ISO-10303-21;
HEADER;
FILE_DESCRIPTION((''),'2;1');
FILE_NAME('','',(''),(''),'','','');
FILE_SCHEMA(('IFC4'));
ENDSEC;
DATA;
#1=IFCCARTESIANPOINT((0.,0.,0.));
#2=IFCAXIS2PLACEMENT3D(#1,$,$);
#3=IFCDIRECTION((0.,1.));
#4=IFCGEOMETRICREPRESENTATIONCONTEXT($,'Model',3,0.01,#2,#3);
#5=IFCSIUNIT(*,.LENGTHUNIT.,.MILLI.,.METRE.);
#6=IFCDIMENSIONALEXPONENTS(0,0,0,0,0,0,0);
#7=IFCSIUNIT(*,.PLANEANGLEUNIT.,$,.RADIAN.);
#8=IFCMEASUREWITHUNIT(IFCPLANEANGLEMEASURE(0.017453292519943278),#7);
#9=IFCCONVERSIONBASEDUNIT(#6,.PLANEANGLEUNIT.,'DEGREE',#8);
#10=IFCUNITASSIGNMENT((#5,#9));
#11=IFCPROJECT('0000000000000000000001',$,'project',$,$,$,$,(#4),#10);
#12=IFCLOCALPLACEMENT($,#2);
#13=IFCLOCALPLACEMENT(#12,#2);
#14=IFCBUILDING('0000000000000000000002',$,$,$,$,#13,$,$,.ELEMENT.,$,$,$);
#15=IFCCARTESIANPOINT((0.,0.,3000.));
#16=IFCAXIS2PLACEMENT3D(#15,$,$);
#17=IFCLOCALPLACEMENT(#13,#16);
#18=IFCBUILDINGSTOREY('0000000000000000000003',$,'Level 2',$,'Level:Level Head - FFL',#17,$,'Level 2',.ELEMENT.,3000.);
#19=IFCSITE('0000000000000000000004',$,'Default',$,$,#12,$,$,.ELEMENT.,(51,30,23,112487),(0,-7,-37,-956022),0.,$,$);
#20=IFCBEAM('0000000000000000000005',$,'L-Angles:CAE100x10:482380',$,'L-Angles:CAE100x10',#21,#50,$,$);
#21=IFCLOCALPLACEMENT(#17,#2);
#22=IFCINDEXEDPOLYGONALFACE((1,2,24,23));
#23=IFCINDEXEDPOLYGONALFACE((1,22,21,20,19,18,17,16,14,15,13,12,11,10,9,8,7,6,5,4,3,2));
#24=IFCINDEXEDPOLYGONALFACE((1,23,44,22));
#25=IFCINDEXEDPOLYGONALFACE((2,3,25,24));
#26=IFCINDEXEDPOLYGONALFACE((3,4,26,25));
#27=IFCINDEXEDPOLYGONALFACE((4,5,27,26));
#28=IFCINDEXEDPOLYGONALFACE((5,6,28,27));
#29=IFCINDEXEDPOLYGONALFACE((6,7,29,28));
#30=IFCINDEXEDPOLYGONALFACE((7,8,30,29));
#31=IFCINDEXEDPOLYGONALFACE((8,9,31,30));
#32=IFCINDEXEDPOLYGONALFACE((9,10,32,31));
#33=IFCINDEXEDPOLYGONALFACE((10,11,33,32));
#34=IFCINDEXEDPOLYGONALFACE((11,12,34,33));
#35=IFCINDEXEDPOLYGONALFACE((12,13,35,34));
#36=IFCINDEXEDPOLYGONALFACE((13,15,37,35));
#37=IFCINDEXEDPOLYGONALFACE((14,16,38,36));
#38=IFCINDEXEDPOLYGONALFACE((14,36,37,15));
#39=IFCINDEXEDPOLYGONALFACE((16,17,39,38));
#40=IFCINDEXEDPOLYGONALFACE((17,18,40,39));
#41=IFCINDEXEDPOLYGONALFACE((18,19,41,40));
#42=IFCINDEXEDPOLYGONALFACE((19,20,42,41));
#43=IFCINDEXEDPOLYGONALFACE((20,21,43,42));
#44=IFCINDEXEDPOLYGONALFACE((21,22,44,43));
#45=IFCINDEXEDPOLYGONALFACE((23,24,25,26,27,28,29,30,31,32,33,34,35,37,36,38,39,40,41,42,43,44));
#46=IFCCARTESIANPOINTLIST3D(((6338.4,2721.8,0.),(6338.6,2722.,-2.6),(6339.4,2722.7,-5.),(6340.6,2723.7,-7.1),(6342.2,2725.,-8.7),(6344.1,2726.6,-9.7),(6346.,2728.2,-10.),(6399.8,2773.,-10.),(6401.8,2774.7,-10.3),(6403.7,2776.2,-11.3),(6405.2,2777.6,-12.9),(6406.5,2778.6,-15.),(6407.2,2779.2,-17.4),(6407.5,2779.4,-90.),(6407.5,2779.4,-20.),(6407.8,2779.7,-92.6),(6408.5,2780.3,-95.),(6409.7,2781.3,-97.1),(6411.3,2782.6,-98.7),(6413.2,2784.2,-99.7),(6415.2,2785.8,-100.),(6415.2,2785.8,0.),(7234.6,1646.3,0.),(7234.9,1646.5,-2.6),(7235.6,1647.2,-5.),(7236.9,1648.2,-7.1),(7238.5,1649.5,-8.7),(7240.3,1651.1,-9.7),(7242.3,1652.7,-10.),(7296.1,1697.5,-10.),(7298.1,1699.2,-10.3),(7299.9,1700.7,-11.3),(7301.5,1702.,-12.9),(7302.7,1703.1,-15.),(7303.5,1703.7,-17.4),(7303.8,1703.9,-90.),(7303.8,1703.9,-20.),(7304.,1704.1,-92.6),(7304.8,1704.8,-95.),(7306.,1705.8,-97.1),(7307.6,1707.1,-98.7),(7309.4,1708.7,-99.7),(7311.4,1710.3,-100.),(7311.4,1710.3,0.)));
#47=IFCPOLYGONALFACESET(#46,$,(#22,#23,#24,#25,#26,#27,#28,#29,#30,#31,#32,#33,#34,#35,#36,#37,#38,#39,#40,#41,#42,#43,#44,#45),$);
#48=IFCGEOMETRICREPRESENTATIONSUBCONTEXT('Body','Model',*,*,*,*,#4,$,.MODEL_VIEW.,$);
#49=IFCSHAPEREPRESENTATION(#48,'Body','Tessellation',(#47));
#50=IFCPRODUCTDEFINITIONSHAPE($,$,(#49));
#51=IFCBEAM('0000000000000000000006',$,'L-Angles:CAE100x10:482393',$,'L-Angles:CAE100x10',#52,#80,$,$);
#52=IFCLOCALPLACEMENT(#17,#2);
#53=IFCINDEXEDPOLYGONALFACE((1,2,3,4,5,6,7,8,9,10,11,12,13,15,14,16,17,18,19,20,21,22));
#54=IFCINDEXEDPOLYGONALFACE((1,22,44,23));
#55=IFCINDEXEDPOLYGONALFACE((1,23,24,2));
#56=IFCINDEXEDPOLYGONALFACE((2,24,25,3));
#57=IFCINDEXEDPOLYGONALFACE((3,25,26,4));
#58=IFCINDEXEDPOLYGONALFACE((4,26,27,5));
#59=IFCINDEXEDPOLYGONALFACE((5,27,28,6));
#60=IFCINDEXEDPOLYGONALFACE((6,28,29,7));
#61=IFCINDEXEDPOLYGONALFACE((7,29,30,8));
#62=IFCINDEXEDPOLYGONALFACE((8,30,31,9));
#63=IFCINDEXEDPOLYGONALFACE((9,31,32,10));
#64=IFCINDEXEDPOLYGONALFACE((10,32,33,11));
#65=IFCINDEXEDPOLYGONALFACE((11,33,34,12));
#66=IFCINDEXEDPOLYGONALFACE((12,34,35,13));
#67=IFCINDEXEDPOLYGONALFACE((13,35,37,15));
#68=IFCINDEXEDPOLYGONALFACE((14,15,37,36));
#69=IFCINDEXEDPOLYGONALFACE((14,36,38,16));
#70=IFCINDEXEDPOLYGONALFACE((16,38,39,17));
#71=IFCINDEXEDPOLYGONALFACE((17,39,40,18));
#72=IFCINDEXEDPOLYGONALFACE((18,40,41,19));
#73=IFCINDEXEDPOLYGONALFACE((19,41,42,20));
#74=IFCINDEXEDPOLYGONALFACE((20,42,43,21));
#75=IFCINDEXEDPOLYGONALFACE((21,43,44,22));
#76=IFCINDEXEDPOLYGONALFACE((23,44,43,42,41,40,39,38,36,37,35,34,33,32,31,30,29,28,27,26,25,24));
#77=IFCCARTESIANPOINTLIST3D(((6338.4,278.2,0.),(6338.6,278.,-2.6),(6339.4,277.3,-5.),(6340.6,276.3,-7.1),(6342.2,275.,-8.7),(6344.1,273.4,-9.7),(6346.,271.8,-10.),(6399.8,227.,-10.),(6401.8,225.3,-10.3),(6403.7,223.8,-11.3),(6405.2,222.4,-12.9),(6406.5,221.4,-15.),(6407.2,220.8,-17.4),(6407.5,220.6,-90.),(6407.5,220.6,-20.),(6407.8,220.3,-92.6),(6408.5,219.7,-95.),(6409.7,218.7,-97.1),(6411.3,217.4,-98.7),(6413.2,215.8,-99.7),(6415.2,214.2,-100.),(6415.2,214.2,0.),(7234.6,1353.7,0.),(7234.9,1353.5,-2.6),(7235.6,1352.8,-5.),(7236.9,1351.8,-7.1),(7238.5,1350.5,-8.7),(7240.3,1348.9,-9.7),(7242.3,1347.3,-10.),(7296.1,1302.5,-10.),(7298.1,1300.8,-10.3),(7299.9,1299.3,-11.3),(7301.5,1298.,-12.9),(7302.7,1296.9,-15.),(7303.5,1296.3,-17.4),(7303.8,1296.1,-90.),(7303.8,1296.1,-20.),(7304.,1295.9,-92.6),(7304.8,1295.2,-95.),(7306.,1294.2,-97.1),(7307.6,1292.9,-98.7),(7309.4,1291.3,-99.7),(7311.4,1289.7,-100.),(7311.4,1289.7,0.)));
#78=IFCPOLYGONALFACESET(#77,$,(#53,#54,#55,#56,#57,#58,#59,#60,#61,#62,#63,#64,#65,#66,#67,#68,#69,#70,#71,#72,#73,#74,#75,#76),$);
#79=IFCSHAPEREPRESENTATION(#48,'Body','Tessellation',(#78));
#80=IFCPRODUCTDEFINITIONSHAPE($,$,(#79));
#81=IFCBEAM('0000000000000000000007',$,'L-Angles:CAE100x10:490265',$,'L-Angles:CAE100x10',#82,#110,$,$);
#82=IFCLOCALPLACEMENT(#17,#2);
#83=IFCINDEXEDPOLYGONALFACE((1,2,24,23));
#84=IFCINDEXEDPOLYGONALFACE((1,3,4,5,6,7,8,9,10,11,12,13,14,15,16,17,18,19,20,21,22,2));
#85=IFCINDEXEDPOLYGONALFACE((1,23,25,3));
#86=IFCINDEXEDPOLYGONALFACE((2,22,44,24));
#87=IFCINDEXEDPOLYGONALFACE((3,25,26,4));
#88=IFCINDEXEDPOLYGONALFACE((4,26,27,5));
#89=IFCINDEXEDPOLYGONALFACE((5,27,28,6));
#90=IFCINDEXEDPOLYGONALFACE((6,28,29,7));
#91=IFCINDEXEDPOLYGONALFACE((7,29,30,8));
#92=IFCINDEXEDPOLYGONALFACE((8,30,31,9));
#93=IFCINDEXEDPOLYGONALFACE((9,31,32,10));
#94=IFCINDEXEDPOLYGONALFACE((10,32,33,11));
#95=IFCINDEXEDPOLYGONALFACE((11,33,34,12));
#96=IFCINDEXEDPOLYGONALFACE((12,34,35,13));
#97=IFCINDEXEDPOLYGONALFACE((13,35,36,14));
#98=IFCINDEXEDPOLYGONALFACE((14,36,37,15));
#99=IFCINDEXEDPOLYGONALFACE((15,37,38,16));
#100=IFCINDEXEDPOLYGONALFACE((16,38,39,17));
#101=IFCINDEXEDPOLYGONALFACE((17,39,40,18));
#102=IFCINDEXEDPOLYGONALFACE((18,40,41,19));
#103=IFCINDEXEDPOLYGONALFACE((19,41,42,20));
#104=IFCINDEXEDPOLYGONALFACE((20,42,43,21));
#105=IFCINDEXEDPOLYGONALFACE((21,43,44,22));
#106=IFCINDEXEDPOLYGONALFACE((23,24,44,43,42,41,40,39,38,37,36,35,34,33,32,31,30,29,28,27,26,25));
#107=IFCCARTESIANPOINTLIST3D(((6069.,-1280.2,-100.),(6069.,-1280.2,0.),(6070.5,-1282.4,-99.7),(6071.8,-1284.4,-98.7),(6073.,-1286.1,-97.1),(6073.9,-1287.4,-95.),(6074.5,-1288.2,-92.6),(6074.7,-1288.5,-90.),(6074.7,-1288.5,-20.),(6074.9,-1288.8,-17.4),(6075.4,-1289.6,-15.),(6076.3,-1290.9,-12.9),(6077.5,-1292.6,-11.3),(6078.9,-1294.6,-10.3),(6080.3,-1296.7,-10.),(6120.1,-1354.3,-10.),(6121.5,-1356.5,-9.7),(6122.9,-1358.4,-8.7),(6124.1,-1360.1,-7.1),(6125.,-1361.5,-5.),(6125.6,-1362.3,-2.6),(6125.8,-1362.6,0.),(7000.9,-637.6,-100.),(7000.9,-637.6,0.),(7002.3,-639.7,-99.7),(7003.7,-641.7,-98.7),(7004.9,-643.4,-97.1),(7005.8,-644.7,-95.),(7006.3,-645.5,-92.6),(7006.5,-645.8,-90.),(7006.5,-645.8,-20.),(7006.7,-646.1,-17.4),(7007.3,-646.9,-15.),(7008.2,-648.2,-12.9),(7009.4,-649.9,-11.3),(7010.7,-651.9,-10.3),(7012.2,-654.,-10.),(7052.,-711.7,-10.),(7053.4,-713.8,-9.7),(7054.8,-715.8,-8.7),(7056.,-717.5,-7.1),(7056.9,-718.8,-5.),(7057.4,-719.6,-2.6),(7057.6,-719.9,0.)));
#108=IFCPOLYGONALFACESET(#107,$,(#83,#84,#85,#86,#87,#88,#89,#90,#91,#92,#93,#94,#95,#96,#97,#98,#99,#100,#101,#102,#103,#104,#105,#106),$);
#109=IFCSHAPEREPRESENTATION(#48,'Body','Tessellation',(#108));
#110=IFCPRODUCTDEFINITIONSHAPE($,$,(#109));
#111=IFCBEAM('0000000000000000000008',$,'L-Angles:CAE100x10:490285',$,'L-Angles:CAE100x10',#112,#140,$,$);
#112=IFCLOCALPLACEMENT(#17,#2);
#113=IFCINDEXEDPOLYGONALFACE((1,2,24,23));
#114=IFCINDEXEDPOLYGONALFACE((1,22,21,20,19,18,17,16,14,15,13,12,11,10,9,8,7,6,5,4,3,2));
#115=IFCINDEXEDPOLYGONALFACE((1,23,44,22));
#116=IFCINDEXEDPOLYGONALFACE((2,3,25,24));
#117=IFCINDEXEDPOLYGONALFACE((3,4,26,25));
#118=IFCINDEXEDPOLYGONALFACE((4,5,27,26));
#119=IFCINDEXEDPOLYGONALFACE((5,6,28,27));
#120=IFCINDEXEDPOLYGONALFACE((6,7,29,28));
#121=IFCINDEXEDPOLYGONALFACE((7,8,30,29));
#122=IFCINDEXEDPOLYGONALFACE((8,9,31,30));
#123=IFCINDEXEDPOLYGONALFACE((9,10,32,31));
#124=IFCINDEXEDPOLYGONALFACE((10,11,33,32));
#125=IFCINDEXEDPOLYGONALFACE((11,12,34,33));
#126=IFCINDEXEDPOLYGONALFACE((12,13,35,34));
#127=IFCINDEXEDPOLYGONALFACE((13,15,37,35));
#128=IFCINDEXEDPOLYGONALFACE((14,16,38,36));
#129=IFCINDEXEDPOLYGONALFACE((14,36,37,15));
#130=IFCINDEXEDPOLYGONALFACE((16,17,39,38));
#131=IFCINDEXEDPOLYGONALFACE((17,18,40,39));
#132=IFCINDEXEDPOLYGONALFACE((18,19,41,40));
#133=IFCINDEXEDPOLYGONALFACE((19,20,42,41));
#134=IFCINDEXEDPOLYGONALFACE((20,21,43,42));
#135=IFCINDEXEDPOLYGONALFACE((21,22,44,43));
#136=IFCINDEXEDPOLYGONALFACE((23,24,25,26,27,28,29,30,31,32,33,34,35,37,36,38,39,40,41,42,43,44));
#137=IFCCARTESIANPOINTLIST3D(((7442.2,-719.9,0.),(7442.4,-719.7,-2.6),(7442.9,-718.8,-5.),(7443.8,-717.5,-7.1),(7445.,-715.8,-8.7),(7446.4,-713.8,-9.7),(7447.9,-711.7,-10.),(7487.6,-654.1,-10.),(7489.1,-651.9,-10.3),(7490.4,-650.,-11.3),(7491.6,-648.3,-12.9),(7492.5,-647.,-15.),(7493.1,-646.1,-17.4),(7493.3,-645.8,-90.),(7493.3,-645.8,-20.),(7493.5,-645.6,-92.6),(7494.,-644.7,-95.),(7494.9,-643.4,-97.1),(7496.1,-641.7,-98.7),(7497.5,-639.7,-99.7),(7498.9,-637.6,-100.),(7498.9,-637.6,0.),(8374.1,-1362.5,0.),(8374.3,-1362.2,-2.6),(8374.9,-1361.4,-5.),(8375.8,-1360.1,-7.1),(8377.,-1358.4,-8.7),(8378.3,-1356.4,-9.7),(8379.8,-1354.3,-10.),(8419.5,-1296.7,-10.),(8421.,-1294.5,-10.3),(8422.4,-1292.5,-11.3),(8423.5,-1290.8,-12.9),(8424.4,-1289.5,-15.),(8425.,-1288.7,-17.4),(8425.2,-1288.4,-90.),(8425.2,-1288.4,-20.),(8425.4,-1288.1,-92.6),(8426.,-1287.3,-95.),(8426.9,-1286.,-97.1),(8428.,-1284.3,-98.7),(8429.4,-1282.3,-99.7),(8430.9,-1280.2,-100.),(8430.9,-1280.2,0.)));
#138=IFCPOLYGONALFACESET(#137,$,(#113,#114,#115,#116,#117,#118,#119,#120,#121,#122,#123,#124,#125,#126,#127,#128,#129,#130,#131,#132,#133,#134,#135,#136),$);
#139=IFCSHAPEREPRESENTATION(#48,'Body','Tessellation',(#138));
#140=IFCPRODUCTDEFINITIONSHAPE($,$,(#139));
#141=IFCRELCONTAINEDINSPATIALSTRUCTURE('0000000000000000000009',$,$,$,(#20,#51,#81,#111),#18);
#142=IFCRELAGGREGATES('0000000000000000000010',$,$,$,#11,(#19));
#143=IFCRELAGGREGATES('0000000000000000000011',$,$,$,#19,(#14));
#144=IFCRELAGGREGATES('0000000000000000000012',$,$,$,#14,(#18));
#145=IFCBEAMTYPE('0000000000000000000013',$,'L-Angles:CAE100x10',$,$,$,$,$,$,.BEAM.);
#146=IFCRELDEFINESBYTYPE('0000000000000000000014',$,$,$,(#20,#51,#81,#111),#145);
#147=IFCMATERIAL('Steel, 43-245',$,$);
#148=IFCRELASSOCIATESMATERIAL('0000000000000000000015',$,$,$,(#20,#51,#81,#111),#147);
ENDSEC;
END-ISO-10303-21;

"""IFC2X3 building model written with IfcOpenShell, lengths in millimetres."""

from ifc_helpers import new_model, entity, si_unit, converted_unit, direction, frame, frame_2d, origin, place, context, subcontext, project, spatial, polyline, circle_curve, parameter, trimmed, segment, composite_curve, outline, extrude, material, type_object, element, save


model = new_model("IFC2X3")

# Units and contexts
model_context = context("Model", 3, precision=0.01, world=origin(), true_north=direction((0.0, 1.0)))
body_context = subcontext(model_context, "Body", "Model", "MODEL_VIEW")
ifc_project = project(units=[si_unit("LENGTHUNIT", "METRE", prefix="MILLI"), converted_unit("PLANEANGLEUNIT", "DEGREE", entity("IfcPlaneAngleMeasure", 0.017453292519943278), si_unit("PLANEANGLEUNIT", "RADIAN"), dimensions=[0, 0, 0, 0, 0, 0, 0])], contexts=[model_context])

# Site, building, storey
site_placement = place(None, origin())
site = spatial("IfcSite", under=ifc_project, at=site_placement, Name="Default", CompositionType="ELEMENT", RefLatitude=(51, 30, 23, 112487), RefLongitude=(0, -7, -37, -956022), RefElevation=0.0)
building_placement = place(site_placement, origin())
building = spatial("IfcBuilding", under=site, at=building_placement, CompositionType="ELEMENT")
storey_placement = place(building_placement, frame((0.0, 0.0, 3000.0)))
storey = spatial("IfcBuildingStorey", under=building, at=storey_placement, Name="Level 2", ObjectType="Level:Level Head - FFL", LongName="Level 2", CompositionType="ELEMENT", Elevation=3000.0)

# Beams
ifc_material = material(Name="Steel, 43-245")
beam_type_1 = type_object("IfcBeamType", Name="L-Angles:CAE100x10", PredefinedType="BEAM")
beam_1_placement = place(storey_placement, frame((6200.0, 3000.0, 0.0), z_axis=(0.0, 0.0, 1.0), x_axis=(0.640184, -0.768221, 0.0)))
element("IfcBeam", 1, at=beam_1_placement, inside=storey, type_object=beam_type_1, material=ifc_material, Name="L-Angles:CAE100x10:482380", ObjectType="L-Angles:CAE100x10", context=body_context, shape_type="SweptSolid", body=[
    extrude(outline(composite_curve([segment(polyline([(-67.1, -32.9), (32.9, -32.9)]), True, "CONTINUOUS"), segment(polyline([(32.9, -32.9), (32.9, 67.1)]), True, "CONTINUOUS"), segment(trimmed(circle_curve(frame_2d((32.9, 57.1), x_axis=(0.0, 1.0)), 10.0), [parameter(0.0)], [parameter(90.0)], True, "PARAMETER"), True, "CONTINUOUS"), segment(polyline([(22.9, 57.1), (22.9, -12.9)]), True, "CONTINUOUS"), segment(trimmed(circle_curve(frame_2d((12.9, -12.9), x_axis=(1.0, 0.0)), 10.0), [parameter(270.0)], [parameter(0.0)], True, "PARAMETER"), False, "CONTINUOUS"), segment(polyline([(12.9, -22.9), (-57.1, -22.9)]), True, "CONTINUOUS"), segment(trimmed(circle_curve(frame_2d((-57.1, -32.9), x_axis=(0.0, 1.0)), 10.0), [parameter(0.0)], [parameter(90.0)], True, "PARAMETER"), True, "CONTINUOUS")], self_intersect=False)), frame((302.3, -4.7, -32.9), z_axis=(1.0, 0.0, 0.0), x_axis=(0.0, 0.0, 1.0)), (0.0, 0.0, 1.0), 1400.0),
])
beam_2_placement = place(storey_placement, frame((6200.0, 0.0, 0.0), z_axis=(0.0, 0.0, 1.0), x_axis=(0.640184, 0.768221, 0.0)))
element("IfcBeam", 2, at=beam_2_placement, inside=storey, type_object=beam_type_1, material=ifc_material, Name="L-Angles:CAE100x10:482393", ObjectType="L-Angles:CAE100x10", context=body_context, shape_type="SweptSolid", body=[
    extrude(outline(composite_curve([segment(polyline([(-32.9, -32.9), (67.1, -32.9)]), True, "CONTINUOUS"), segment(trimmed(circle_curve(frame_2d((57.1, -32.9), x_axis=(1.0, 0.0)), 10.0), [parameter(0.0)], [parameter(90.0)], True, "PARAMETER"), True, "CONTINUOUS"), segment(polyline([(57.1, -22.9), (-12.9, -22.9)]), True, "CONTINUOUS"), segment(trimmed(circle_curve(frame_2d((-12.9, -12.9), x_axis=(0.0, -1.0)), 10.0), [parameter(270.0)], [parameter(0.0)], True, "PARAMETER"), False, "CONTINUOUS"), segment(polyline([(-22.9, -12.9), (-22.9, 57.1)]), True, "CONTINUOUS"), segment(trimmed(circle_curve(frame_2d((-32.9, 57.1), x_axis=(1.0, 0.0)), 10.0), [parameter(0.0)], [parameter(90.0)], True, "PARAMETER"), True, "CONTINUOUS"), segment(polyline([(-32.9, 67.1), (-32.9, -32.9)]), True, "CONTINUOUS")], self_intersect=False)), frame((302.3, 4.7, -32.9), z_axis=(1.0, 0.0, 0.0), x_axis=(0.0, 0.0, -1.0)), (0.0, 0.0, 1.0), 1400.0),
])
beam_3_placement = place(storey_placement, frame((5800.0, -1500.0, 0.0), z_axis=(0.0, 0.0, 1.0), x_axis=(0.823213, 0.567733, 0.0)))
element("IfcBeam", 3, at=beam_3_placement, inside=storey, type_object=beam_type_1, material=ifc_material, Name="L-Angles:CAE100x10:490265", ObjectType="L-Angles:CAE100x10", context=body_context, shape_type="SweptSolid", body=[
    extrude(outline(composite_curve([segment(polyline([(-67.1, -32.9), (32.9, -32.9)]), True, "CONTINUOUS"), segment(polyline([(32.9, -32.9), (32.9, 67.1)]), True, "CONTINUOUS"), segment(trimmed(circle_curve(frame_2d((32.9, 57.1), x_axis=(0.0, 1.0)), 10.0), [parameter(0.0)], [parameter(90.0)], True, "PARAMETER"), True, "CONTINUOUS"), segment(polyline([(22.9, 57.1), (22.9, -12.9)]), True, "CONTINUOUS"), segment(trimmed(circle_curve(frame_2d((12.9, -12.9), x_axis=(1.0, 0.0)), 10.0), [parameter(270.0)], [parameter(0.0)], True, "PARAMETER"), False, "CONTINUOUS"), segment(polyline([(12.9, -22.9), (-57.1, -22.9)]), True, "CONTINUOUS"), segment(trimmed(circle_curve(frame_2d((-57.1, -32.9), x_axis=(0.0, 1.0)), 10.0), [parameter(0.0)], [parameter(90.0)], True, "PARAMETER"), True, "CONTINUOUS")], self_intersect=False)), frame((346.2, -4.7, -32.9), z_axis=(1.0, 0.0, 0.0), x_axis=(0.0, 0.0, 1.0)), (0.0, 0.0, 1.0), 1132.0),
])
beam_4_placement = place(storey_placement, frame((7249.7, -500.0, 0.0), z_axis=(0.0, 0.0, 1.0), x_axis=(0.823272, -0.567647, 0.0)))
element("IfcBeam", 4, at=beam_4_placement, inside=storey, type_object=beam_type_1, material=ifc_material, Name="L-Angles:CAE100x10:490285", ObjectType="L-Angles:CAE100x10", context=body_context, shape_type="SweptSolid", body=[
    extrude(outline(composite_curve([segment(polyline([(-67.1, -32.9), (32.9, -32.9)]), True, "CONTINUOUS"), segment(polyline([(32.9, -32.9), (32.9, 67.1)]), True, "CONTINUOUS"), segment(trimmed(circle_curve(frame_2d((32.9, 57.1), x_axis=(0.0, 1.0)), 10.0), [parameter(0.0)], [parameter(90.0)], True, "PARAMETER"), True, "CONTINUOUS"), segment(polyline([(22.9, 57.1), (22.9, -12.9)]), True, "CONTINUOUS"), segment(trimmed(circle_curve(frame_2d((12.9, -12.9), x_axis=(1.0, 0.0)), 10.0), [parameter(270.0)], [parameter(0.0)], True, "PARAMETER"), False, "CONTINUOUS"), segment(polyline([(12.9, -22.9), (-57.1, -22.9)]), True, "CONTINUOUS"), segment(trimmed(circle_curve(frame_2d((-57.1, -32.9), x_axis=(0.0, 1.0)), 10.0), [parameter(0.0)], [parameter(90.0)], True, "PARAMETER"), True, "CONTINUOUS")], self_intersect=False)), frame((283.3, -4.7, -32.9), z_axis=(1.0, 0.0, 0.0), x_axis=(0.0, 0.0, 1.0)), (0.0, 0.0, 1.0), 1132.0),
])

save(model, "model.ifc")
